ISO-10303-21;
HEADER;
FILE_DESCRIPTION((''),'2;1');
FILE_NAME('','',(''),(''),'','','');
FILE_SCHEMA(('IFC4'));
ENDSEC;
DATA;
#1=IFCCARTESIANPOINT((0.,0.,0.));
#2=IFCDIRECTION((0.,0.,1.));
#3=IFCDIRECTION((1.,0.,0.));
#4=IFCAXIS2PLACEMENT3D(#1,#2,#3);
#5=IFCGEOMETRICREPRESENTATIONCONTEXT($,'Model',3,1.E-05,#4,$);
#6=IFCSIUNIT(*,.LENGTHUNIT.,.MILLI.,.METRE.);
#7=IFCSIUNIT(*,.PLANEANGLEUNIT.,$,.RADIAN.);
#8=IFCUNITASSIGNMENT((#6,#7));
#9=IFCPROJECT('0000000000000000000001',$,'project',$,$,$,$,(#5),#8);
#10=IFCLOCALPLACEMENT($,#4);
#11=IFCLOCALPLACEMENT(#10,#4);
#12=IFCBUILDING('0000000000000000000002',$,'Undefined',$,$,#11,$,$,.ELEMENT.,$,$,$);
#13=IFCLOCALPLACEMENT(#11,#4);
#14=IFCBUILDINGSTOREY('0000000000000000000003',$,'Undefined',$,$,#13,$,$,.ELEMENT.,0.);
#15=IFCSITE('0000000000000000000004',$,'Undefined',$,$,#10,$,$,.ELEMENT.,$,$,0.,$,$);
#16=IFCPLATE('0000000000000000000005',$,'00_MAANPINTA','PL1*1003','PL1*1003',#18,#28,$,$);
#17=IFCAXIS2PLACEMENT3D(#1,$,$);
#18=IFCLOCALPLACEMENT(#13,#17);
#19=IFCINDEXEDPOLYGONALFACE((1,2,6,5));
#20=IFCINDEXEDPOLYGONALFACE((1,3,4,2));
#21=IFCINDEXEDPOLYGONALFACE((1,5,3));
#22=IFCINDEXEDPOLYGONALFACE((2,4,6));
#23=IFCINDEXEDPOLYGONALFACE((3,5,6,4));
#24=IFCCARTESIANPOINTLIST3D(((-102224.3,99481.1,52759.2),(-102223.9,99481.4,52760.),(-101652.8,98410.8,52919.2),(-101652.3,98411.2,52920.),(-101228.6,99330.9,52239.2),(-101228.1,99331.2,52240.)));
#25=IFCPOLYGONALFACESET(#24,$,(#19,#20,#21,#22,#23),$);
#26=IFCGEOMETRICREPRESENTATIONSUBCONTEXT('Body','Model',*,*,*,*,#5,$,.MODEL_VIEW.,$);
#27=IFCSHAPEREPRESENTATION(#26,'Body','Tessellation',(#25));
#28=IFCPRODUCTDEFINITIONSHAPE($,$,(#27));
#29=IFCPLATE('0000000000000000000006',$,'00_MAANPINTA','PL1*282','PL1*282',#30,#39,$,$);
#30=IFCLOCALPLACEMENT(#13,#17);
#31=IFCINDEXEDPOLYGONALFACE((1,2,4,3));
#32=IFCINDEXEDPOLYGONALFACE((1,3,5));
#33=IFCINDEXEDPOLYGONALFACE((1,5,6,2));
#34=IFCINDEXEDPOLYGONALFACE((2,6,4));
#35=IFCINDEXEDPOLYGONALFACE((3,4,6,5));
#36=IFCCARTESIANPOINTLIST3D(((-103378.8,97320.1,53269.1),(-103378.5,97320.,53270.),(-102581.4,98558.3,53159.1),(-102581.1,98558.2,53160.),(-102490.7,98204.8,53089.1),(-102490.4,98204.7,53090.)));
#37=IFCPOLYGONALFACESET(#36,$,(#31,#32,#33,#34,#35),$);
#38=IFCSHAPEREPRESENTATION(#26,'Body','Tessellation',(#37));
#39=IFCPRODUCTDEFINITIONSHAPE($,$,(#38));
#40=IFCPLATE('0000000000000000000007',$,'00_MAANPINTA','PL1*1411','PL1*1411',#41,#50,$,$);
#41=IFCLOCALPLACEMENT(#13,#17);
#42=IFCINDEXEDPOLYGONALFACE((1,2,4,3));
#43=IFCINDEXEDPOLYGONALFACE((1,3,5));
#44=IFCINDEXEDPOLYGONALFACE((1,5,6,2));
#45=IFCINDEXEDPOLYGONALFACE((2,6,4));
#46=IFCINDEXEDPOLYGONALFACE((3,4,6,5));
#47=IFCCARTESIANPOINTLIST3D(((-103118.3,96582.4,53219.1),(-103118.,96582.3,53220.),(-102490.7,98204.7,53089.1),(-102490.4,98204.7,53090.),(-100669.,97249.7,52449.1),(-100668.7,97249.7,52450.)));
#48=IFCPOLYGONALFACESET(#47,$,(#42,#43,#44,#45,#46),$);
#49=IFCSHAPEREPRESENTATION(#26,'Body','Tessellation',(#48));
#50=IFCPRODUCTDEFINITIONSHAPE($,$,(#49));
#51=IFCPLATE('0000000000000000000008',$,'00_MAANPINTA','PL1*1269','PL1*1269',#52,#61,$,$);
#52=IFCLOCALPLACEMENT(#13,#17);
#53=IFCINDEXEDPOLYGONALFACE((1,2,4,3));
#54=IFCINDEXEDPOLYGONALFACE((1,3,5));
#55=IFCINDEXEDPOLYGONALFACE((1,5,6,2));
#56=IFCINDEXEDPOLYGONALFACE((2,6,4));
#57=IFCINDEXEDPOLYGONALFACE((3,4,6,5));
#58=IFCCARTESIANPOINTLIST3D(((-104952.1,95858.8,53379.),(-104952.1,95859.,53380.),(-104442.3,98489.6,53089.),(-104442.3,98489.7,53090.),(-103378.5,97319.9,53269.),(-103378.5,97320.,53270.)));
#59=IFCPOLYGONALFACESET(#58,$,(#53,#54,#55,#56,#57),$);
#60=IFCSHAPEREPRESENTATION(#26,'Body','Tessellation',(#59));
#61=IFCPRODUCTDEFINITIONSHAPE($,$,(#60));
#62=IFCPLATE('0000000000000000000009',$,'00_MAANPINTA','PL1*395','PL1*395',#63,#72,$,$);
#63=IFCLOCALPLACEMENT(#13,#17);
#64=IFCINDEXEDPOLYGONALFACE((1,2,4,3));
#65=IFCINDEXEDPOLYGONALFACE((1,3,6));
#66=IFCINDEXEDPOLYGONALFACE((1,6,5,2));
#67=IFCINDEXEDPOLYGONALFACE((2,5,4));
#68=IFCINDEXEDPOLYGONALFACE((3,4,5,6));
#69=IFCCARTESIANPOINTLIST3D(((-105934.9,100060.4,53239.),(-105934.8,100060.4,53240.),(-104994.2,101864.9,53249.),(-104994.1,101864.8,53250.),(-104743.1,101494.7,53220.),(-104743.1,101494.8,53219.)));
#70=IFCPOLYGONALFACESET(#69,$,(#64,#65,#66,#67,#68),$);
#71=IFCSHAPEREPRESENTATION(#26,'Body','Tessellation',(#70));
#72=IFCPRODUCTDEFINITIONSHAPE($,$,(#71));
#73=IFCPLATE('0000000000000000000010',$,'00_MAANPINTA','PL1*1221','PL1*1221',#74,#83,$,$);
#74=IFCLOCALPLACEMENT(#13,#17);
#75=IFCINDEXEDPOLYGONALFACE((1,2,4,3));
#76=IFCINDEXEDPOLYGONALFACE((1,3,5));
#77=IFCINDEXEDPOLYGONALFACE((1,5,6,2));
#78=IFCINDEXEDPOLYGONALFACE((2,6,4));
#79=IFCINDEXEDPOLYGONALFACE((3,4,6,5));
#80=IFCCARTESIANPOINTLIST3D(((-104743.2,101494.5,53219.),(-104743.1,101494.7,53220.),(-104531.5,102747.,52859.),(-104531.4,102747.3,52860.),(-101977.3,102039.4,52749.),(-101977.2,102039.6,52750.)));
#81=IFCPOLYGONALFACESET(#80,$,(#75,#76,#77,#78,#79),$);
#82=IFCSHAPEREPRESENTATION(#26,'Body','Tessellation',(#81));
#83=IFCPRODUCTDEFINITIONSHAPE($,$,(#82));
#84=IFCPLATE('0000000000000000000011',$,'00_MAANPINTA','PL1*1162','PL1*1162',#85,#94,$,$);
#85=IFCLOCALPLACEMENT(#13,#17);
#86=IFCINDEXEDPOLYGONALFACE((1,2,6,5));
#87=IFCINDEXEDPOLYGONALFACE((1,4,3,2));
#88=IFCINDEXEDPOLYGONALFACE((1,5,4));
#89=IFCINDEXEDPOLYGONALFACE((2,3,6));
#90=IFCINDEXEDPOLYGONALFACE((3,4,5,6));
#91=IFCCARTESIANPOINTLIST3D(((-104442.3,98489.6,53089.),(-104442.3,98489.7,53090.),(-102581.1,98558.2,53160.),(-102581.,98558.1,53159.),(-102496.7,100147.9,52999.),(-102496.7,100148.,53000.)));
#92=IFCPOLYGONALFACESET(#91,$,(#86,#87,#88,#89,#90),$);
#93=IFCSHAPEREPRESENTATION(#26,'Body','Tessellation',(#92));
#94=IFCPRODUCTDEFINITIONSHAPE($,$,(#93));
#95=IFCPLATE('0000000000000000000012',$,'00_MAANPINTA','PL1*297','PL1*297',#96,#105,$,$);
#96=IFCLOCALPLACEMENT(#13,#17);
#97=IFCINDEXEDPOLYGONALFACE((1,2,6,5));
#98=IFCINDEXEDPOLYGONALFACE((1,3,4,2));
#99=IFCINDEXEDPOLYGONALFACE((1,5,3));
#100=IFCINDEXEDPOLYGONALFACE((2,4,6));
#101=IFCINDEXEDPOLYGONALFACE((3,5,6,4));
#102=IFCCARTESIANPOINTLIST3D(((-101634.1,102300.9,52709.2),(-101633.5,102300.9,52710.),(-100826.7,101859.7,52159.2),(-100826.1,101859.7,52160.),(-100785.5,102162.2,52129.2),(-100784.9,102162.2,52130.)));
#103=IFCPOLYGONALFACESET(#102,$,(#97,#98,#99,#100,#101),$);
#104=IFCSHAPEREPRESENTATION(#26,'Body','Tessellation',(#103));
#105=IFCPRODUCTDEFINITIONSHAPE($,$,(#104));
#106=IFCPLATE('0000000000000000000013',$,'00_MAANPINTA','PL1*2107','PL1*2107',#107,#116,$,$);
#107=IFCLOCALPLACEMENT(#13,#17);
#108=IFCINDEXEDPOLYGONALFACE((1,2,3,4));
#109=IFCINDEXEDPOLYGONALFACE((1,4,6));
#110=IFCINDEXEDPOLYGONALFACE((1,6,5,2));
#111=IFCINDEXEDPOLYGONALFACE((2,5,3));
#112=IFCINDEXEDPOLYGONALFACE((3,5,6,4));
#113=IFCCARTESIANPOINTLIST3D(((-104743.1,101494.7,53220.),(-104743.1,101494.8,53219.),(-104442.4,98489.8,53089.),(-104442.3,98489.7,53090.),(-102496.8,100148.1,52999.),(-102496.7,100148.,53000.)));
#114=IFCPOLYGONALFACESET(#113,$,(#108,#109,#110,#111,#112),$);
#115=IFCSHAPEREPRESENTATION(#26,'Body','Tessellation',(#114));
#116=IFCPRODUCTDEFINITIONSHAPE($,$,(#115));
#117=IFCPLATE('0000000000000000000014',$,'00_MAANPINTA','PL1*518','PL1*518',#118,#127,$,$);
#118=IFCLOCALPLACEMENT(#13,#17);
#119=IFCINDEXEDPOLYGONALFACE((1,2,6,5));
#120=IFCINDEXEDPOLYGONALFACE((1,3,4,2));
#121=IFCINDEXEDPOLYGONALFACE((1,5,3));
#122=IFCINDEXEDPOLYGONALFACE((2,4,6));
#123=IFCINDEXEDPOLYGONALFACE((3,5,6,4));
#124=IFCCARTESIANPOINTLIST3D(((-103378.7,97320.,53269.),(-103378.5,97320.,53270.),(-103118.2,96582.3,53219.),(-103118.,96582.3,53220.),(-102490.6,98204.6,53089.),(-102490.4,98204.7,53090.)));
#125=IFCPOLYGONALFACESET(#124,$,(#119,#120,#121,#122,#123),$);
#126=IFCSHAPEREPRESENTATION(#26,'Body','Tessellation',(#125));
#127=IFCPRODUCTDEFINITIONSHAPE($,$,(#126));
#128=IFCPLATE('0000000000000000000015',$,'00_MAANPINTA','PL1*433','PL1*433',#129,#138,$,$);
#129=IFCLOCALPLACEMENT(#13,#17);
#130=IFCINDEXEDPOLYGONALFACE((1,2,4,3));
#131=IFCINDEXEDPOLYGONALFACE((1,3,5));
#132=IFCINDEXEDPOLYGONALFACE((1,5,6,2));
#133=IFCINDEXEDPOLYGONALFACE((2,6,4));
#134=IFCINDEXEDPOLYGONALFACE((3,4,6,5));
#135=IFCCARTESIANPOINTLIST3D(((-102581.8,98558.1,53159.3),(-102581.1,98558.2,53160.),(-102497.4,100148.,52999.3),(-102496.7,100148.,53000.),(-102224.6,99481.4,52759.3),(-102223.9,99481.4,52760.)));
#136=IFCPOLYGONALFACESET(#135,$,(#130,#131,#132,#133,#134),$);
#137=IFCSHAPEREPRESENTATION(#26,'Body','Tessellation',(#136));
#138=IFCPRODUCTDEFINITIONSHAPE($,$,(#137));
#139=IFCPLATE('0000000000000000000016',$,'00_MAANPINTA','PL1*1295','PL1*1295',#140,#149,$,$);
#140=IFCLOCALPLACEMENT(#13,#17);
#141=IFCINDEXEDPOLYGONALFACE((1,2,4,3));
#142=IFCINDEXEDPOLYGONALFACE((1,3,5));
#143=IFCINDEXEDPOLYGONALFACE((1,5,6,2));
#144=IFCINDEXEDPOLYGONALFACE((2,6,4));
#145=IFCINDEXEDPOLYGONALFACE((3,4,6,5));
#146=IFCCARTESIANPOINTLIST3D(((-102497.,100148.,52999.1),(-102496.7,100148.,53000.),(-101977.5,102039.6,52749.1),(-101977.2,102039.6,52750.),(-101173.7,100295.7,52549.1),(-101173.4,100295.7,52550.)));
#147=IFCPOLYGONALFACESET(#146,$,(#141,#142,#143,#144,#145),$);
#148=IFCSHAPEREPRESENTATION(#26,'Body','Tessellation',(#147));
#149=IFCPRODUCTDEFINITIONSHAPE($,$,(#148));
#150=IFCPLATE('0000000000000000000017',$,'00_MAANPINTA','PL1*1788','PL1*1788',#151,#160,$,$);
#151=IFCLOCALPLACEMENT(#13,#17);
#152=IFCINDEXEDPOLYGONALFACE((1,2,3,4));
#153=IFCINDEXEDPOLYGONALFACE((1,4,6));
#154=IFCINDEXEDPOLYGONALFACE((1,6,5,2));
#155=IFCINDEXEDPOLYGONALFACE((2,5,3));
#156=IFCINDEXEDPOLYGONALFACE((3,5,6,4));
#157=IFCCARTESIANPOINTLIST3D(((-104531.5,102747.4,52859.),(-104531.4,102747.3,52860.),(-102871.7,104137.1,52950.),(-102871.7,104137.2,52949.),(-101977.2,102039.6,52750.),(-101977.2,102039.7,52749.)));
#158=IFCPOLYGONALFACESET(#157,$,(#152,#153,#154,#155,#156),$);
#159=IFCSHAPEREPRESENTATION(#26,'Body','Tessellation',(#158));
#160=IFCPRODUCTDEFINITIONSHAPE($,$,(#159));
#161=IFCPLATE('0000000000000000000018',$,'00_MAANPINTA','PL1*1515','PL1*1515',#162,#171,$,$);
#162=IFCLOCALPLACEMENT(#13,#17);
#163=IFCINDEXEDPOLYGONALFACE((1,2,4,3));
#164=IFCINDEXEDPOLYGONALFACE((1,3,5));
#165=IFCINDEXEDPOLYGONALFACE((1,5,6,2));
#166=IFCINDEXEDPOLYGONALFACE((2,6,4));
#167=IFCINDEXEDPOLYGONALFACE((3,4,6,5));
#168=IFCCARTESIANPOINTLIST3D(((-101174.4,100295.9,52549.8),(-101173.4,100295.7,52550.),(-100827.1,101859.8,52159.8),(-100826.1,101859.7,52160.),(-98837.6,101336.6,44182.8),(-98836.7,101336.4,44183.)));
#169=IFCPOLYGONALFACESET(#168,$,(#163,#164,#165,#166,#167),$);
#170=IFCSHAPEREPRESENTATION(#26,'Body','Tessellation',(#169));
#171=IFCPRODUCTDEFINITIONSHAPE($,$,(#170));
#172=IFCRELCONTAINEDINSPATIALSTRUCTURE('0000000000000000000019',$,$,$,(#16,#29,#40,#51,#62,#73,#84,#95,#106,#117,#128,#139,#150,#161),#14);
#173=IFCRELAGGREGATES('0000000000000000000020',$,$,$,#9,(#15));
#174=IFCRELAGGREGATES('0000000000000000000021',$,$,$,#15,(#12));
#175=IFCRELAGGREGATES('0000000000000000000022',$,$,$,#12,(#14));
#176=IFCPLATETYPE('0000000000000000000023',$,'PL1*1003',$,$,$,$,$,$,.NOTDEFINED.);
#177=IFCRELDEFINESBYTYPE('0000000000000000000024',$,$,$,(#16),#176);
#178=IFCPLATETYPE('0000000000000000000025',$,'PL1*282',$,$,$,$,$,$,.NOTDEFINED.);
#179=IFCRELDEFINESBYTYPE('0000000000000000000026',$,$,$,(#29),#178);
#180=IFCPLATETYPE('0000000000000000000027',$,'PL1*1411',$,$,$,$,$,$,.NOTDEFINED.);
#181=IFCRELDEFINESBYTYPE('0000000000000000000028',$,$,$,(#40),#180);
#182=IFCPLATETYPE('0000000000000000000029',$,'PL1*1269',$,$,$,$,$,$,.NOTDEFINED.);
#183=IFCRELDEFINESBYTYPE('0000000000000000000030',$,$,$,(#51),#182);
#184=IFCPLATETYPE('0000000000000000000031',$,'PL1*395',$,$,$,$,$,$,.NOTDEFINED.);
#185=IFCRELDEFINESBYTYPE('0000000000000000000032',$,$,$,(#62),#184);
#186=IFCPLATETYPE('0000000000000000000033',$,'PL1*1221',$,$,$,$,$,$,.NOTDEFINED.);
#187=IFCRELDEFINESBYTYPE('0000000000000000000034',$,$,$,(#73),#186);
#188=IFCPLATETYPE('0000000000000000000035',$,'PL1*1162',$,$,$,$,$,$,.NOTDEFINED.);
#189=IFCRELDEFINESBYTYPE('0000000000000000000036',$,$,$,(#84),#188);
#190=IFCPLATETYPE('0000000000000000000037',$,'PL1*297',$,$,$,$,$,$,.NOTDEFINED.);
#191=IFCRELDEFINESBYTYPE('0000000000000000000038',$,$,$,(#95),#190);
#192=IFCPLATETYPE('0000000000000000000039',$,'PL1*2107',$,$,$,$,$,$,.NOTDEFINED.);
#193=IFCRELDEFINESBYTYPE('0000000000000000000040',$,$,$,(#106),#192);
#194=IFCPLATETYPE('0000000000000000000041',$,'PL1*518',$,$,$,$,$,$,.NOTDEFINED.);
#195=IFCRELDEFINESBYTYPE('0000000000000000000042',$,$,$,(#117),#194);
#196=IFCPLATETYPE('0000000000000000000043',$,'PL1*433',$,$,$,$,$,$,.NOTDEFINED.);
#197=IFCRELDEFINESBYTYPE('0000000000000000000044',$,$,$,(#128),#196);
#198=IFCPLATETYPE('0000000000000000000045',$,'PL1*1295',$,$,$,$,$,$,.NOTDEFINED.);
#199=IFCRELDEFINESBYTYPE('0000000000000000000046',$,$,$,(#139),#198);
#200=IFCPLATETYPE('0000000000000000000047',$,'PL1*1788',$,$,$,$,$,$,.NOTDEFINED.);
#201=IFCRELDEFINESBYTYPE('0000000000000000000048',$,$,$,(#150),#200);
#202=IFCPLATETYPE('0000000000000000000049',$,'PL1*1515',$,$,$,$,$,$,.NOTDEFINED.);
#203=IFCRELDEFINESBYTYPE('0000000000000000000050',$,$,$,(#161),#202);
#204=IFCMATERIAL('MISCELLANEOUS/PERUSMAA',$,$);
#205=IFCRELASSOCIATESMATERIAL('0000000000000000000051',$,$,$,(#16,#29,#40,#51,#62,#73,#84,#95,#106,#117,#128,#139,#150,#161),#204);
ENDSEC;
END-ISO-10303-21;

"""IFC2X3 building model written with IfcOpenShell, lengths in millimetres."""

from ifc_helpers import new_model, si_unit, frame, origin_with_axes, place, context, subcontext, project, spatial, polyline, outline, extrude, material, type_object, element, save


model = new_model("IFC2X3")

# Units and contexts
model_context = context("Model", 3, precision=1e-05, world=origin_with_axes())
body_context = subcontext(model_context, "Body", "Model", "MODEL_VIEW")
ifc_project = project(units=[si_unit("LENGTHUNIT", "METRE", prefix="MILLI"), si_unit("PLANEANGLEUNIT", "RADIAN")], contexts=[model_context])

# Site, building, storey
site_placement = place(None, origin_with_axes())
site = spatial("IfcSite", under=ifc_project, at=site_placement, Name="Undefined", CompositionType="ELEMENT", RefElevation=0.0)
building_placement = place(site_placement, origin_with_axes())
building = spatial("IfcBuilding", under=site, at=building_placement, Name="Undefined", CompositionType="ELEMENT")
storey_placement = place(building_placement, origin_with_axes())
storey = spatial("IfcBuildingStorey", under=building, at=storey_placement, Name="Undefined", CompositionType="ELEMENT", Elevation=0.0)

# Plates
ifc_material = material(Name="MISCELLANEOUS/PERUSMAA")
plate_type_1 = type_object("IfcPlateType", Name="PL1*1003", PredefinedType="NOTDEFINED")
plate_1_placement = place(storey_placement, frame((-102224.1, 99481.3, 52759.6), z_axis=(-0.473142, -0.372055, -0.798568), x_axis=(0.878594, -0.132523, -0.458814)))
element("IfcPlate", 1, at=plate_1_placement, inside=storey, type_object=plate_type_1, material=ifc_material, Name="00_MAANPINTA", Description="PL1*1003", ObjectType="PL1*1003", context=body_context, shape_type="SweptSolid", body=[
    extrude(outline(polyline([(0.0, 0.0), (1133.4, 0.0), (570.6, 1082.7), (0.0, 0.0)])), frame((0.0, 0.0, -0.5), z_axis=(0.0, 0.0, 1.0), x_axis=(1.0, 0.0, 0.0)), (0.0, 0.0, 1.0), 1.0),
])
plate_type_2 = type_object("IfcPlateType", Name="PL1*282", PredefinedType="NOTDEFINED")
plate_2_placement = place(storey_placement, frame((-102581.2, 98558.2, 53159.5), z_axis=(-0.301647, 0.110141, -0.947036), x_axis=(0.244034, -0.951297, -0.188365)))
element("IfcPlate", 2, at=plate_2_placement, inside=storey, type_object=plate_type_2, material=ifc_material, Name="00_MAANPINTA", Description="PL1*282", ObjectType="PL1*282", context=body_context, shape_type="SweptSolid", body=[
    extrude(outline(polyline([(0.0, 0.0), (371.6, 0.0), (962.5, 1120.1), (0.0, 0.0)])), frame((0.0, 0.0, -0.5), z_axis=(0.0, 0.0, 1.0), x_axis=(1.0, 0.0, 0.0)), (0.0, 0.0, 1.0), 1.0),
])
plate_type_3 = type_object("IfcPlateType", Name="PL1*1411", PredefinedType="NOTDEFINED")
plate_3_placement = place(storey_placement, frame((-102490.5, 98204.7, 53089.5), z_axis=(-0.310512, 0.044038, -0.949549), x_axis=(0.845689, -0.443323, -0.297109)))
element("IfcPlate", 3, at=plate_3_placement, inside=storey, type_object=plate_type_3, material=ifc_material, Name="00_MAANPINTA", Description="PL1*1411", ObjectType="PL1*1411", context=body_context, shape_type="SweptSolid", body=[
    extrude(outline(polyline([(0.0, 0.0), (2154.1, 0.0), (149.8, 1737.9), (0.0, 0.0)])), frame((0.0, 0.0, -0.5), z_axis=(0.0, 0.0, 1.0), x_axis=(1.0, 0.0, 0.0)), (0.0, 0.0, 1.0), 1.0),
])
plate_type_4 = type_object("IfcPlateType", Name="PL1*1269", PredefinedType="NOTDEFINED")
plate_4_placement = place(storey_placement, frame((-104442.3, 98489.7, 53089.5), z_axis=(0.039261, -0.116999, -0.992356), x_axis=(0.6685, -0.73506, 0.113111)))
element("IfcPlate", 4, at=plate_4_placement, inside=storey, type_object=plate_type_4, material=ifc_material, Name="00_MAANPINTA", Description="PL1*1269", ObjectType="PL1*1269", context=body_context, shape_type="SweptSolid", body=[
    extrude(outline(polyline([(0.0, 0.0), (1591.4, 0.0), (1625.8, 2149.8), (0.0, 0.0)])), frame((0.0, 0.0, -0.5), z_axis=(0.0, 0.0, 1.0), x_axis=(1.0, 0.0, 0.0)), (0.0, 0.0, 1.0), 1.0),
])
plate_type_5 = type_object("IfcPlateType", Name="PL1*395", PredefinedType="NOTDEFINED")
plate_5_placement = place(storey_placement, frame((-104994.2, 101864.8, 53249.5), z_axis=(-0.062776, 0.038254, -0.997294), x_axis=(0.560172, -0.825668, -0.066932)))
element("IfcPlate", 5, at=plate_5_placement, inside=storey, type_object=plate_type_5, material=ifc_material, Name="00_MAANPINTA", Description="PL1*395", ObjectType="PL1*395", context=body_context, shape_type="SweptSolid", body=[
    extrude(outline(polyline([(0.0, 0.0), (448.2, 0.0), (963.6, 1792.4), (0.0, 0.0)])), frame((0.0, 0.0, -0.5), z_axis=(0.0, 0.0, 1.0), x_axis=(1.0, 0.0, 0.0)), (0.0, 0.0, 1.0), 1.0),
])
plate_type_6 = type_object("IfcPlateType", Name="PL1*1221", PredefinedType="NOTDEFINED")
plate_6_placement = place(storey_placement, frame((-104531.5, 102747.1, 52859.5), z_axis=(-0.112504, -0.256878, -0.959873), x_axis=(0.962871, -0.266757, -0.041467)))
element("IfcPlate", 6, at=plate_6_placement, inside=storey, type_object=plate_type_6, material=ifc_material, Name="00_MAANPINTA", Description="PL1*1221", ObjectType="PL1*1221", context=body_context, shape_type="SweptSolid", body=[
    extrude(outline(polyline([(0.0, 0.0), (2652.7, 0.0), (115.4, 1315.2), (0.0, 0.0)])), frame((0.0, 0.0, -0.5), z_axis=(0.0, 0.0, 1.0), x_axis=(1.0, 0.0, 0.0)), (0.0, 0.0, 1.0), 1.0),
])
plate_type_7 = type_object("IfcPlateType", Name="PL1*1162", PredefinedType="NOTDEFINED")
plate_7_placement = place(storey_placement, frame((-102496.7, 100148.0, 52999.5), z_axis=(0.041138, -0.102207, -0.993912), x_axis=(-0.052714, -0.993591, 0.099992)))
element("IfcPlate", 7, at=plate_7_placement, inside=storey, type_object=plate_type_7, material=ifc_material, Name="00_MAANPINTA", Description="PL1*1162", ObjectType="PL1*1162", context=body_context, shape_type="SweptSolid", body=[
    extrude(outline(polyline([(0.0, 0.0), (1600.1, 0.0), (1759.2, 1857.0), (0.0, 0.0)])), frame((0.0, 0.0, -0.5), z_axis=(0.0, 0.0, 1.0), x_axis=(1.0, 0.0, 0.0)), (0.0, 0.0, 1.0), 1.0),
])
plate_type_8 = type_object("IfcPlateType", Name="PL1*297", PredefinedType="NOTDEFINED")
plate_8_placement = place(storey_placement, frame((-101633.8, 102300.9, 52709.6), z_axis=(-0.56483, -0.004894, -0.825193), x_axis=(0.818156, -0.133767, -0.55922)))
element("IfcPlate", 8, at=plate_8_placement, inside=storey, type_object=plate_type_8, material=ifc_material, Name="00_MAANPINTA", Description="PL1*297", ObjectType="PL1*297", context=body_context, shape_type="SweptSolid", body=[
    extrude(outline(polyline([(0.0, 0.0), (1037.2, 0.0), (1027.1, 306.6), (0.0, 0.0)])), frame((0.0, 0.0, -0.5), z_axis=(0.0, 0.0, 1.0), x_axis=(1.0, 0.0, 0.0)), (0.0, 0.0, 1.0), 1.0),
])
plate_type_9 = type_object("IfcPlateType", Name="PL1*2107", PredefinedType="NOTDEFINED")
plate_9_placement = place(storey_placement, frame((-104743.1, 101494.8, 53219.5), z_axis=(-0.076325, 0.035469, -0.996452), x_axis=(0.85467, -0.512379, -0.083703)))
element("IfcPlate", 9, at=plate_9_placement, inside=storey, type_object=plate_type_9, material=ifc_material, Name="00_MAANPINTA", Description="PL1*2107", ObjectType="PL1*2107", context=body_context, shape_type="SweptSolid", body=[
    extrude(outline(polyline([(0.0, 0.0), (2628.3, 0.0), (1807.6, 2422.8), (0.0, 0.0)])), frame((0.0, 0.0, -0.5), z_axis=(0.0, 0.0, 1.0), x_axis=(1.0, 0.0, 0.0)), (0.0, 0.0, 1.0), 1.0),
])
plate_type_10 = type_object("IfcPlateType", Name="PL1*518", PredefinedType="NOTDEFINED")
plate_10_placement = place(storey_placement, frame((-103118.1, 96582.3, 53219.5), z_axis=(-0.195999, -0.002752, -0.9806), x_axis=(-0.332327, 0.941005, 0.063784)))
element("IfcPlate", 10, at=plate_10_placement, inside=storey, type_object=plate_type_10, material=ifc_material, Name="00_MAANPINTA", Description="PL1*518", ObjectType="PL1*518", context=body_context, shape_type="SweptSolid", body=[
    extrude(outline(polyline([(0.0, 0.0), (783.9, 0.0), (1309.7, 1152.1), (0.0, 0.0)])), frame((0.0, 0.0, -0.5), z_axis=(0.0, 0.0, 1.0), x_axis=(1.0, 0.0, 0.0)), (0.0, 0.0, 1.0), 1.0),
])
plate_type_11 = type_object("IfcPlateType", Name="PL1*433", PredefinedType="NOTDEFINED")
plate_11_placement = place(storey_placement, frame((-102497.1, 100148.0, 52999.6), z_axis=(-0.705419, -0.033824, -0.707983), x_axis=(0.359367, -0.878023, -0.316118)))
element("IfcPlate", 11, at=plate_11_placement, inside=storey, type_object=plate_type_11, material=ifc_material, Name="00_MAANPINTA", Description="PL1*433", ObjectType="PL1*433", context=body_context, shape_type="SweptSolid", body=[
    extrude(outline(polyline([(0.0, 0.0), (759.2, 0.0), (1315.1, 911.6), (0.0, 0.0)])), frame((0.0, 0.0, -0.5), z_axis=(0.0, 0.0, 1.0), x_axis=(1.0, 0.0, 0.0)), (0.0, 0.0, 1.0), 1.0),
])
plate_type_12 = type_object("IfcPlateType", Name="PL1*1295", PredefinedType="NOTDEFINED")
plate_12_placement = place(storey_placement, frame((-101977.4, 102039.6, 52749.5), z_axis=(-0.317932, -0.037889, -0.947356), x_axis=(0.416331, -0.903292, -0.103594)))
element("IfcPlate", 12, at=plate_12_placement, inside=storey, type_object=plate_type_12, material=ifc_material, Name="00_MAANPINTA", Description="PL1*1295", ObjectType="PL1*1295", context=body_context, shape_type="SweptSolid", body=[
    extrude(outline(polyline([(0.0, 0.0), (1930.6, 0.0), (1466.5, 1326.6), (0.0, 0.0)])), frame((0.0, 0.0, -0.5), z_axis=(0.0, 0.0, 1.0), x_axis=(1.0, 0.0, 0.0)), (0.0, 0.0, 1.0), 1.0),
])
plate_type_13 = type_object("IfcPlateType", Name="PL1*1788", PredefinedType="NOTDEFINED")
plate_13_placement = place(storey_placement, frame((-101977.2, 102039.7, 52749.5), z_axis=(-0.018804, 0.086957, -0.996035), x_axis=(-0.962871, 0.266757, 0.041467)))
element("IfcPlate", 13, at=plate_13_placement, inside=storey, type_object=plate_type_13, material=ifc_material, Name="00_MAANPINTA", Description="PL1*1788", ObjectType="PL1*1788", context=body_context, shape_type="SweptSolid", body=[
    extrude(outline(polyline([(0.0, 0.0), (2652.7, 0.0), (1429.1, 1788.0), (0.0, 0.0)])), frame((0.0, 0.0, -0.5), z_axis=(0.0, 0.0, 1.0), x_axis=(1.0, 0.0, 0.0)), (0.0, 0.0, 1.0), 1.0),
])
plate_type_14 = type_object("IfcPlateType", Name="PL1*1515", PredefinedType="NOTDEFINED")
plate_14_placement = place(storey_placement, frame((-101173.9, 100295.8, 52549.9), z_axis=(-0.956865, 0.150498, -0.248514), x_axis=(0.210616, 0.948523, -0.236529)))
element("IfcPlate", 14, at=plate_14_placement, inside=storey, type_object=plate_type_14, material=ifc_material, Name="00_MAANPINTA", Description="PL1*1515", ObjectType="PL1*1515", context=body_context, shape_type="SweptSolid", body=[
    extrude(outline(polyline([(0.0, 0.0), (1648.8, 0.0), (3458.3, 8036.8), (0.0, 0.0)])), frame((0.0, 0.0, -0.5), z_axis=(0.0, 0.0, 1.0), x_axis=(1.0, 0.0, 0.0)), (0.0, 0.0, 1.0), 1.0),
])

save(model, "model.ifc")
